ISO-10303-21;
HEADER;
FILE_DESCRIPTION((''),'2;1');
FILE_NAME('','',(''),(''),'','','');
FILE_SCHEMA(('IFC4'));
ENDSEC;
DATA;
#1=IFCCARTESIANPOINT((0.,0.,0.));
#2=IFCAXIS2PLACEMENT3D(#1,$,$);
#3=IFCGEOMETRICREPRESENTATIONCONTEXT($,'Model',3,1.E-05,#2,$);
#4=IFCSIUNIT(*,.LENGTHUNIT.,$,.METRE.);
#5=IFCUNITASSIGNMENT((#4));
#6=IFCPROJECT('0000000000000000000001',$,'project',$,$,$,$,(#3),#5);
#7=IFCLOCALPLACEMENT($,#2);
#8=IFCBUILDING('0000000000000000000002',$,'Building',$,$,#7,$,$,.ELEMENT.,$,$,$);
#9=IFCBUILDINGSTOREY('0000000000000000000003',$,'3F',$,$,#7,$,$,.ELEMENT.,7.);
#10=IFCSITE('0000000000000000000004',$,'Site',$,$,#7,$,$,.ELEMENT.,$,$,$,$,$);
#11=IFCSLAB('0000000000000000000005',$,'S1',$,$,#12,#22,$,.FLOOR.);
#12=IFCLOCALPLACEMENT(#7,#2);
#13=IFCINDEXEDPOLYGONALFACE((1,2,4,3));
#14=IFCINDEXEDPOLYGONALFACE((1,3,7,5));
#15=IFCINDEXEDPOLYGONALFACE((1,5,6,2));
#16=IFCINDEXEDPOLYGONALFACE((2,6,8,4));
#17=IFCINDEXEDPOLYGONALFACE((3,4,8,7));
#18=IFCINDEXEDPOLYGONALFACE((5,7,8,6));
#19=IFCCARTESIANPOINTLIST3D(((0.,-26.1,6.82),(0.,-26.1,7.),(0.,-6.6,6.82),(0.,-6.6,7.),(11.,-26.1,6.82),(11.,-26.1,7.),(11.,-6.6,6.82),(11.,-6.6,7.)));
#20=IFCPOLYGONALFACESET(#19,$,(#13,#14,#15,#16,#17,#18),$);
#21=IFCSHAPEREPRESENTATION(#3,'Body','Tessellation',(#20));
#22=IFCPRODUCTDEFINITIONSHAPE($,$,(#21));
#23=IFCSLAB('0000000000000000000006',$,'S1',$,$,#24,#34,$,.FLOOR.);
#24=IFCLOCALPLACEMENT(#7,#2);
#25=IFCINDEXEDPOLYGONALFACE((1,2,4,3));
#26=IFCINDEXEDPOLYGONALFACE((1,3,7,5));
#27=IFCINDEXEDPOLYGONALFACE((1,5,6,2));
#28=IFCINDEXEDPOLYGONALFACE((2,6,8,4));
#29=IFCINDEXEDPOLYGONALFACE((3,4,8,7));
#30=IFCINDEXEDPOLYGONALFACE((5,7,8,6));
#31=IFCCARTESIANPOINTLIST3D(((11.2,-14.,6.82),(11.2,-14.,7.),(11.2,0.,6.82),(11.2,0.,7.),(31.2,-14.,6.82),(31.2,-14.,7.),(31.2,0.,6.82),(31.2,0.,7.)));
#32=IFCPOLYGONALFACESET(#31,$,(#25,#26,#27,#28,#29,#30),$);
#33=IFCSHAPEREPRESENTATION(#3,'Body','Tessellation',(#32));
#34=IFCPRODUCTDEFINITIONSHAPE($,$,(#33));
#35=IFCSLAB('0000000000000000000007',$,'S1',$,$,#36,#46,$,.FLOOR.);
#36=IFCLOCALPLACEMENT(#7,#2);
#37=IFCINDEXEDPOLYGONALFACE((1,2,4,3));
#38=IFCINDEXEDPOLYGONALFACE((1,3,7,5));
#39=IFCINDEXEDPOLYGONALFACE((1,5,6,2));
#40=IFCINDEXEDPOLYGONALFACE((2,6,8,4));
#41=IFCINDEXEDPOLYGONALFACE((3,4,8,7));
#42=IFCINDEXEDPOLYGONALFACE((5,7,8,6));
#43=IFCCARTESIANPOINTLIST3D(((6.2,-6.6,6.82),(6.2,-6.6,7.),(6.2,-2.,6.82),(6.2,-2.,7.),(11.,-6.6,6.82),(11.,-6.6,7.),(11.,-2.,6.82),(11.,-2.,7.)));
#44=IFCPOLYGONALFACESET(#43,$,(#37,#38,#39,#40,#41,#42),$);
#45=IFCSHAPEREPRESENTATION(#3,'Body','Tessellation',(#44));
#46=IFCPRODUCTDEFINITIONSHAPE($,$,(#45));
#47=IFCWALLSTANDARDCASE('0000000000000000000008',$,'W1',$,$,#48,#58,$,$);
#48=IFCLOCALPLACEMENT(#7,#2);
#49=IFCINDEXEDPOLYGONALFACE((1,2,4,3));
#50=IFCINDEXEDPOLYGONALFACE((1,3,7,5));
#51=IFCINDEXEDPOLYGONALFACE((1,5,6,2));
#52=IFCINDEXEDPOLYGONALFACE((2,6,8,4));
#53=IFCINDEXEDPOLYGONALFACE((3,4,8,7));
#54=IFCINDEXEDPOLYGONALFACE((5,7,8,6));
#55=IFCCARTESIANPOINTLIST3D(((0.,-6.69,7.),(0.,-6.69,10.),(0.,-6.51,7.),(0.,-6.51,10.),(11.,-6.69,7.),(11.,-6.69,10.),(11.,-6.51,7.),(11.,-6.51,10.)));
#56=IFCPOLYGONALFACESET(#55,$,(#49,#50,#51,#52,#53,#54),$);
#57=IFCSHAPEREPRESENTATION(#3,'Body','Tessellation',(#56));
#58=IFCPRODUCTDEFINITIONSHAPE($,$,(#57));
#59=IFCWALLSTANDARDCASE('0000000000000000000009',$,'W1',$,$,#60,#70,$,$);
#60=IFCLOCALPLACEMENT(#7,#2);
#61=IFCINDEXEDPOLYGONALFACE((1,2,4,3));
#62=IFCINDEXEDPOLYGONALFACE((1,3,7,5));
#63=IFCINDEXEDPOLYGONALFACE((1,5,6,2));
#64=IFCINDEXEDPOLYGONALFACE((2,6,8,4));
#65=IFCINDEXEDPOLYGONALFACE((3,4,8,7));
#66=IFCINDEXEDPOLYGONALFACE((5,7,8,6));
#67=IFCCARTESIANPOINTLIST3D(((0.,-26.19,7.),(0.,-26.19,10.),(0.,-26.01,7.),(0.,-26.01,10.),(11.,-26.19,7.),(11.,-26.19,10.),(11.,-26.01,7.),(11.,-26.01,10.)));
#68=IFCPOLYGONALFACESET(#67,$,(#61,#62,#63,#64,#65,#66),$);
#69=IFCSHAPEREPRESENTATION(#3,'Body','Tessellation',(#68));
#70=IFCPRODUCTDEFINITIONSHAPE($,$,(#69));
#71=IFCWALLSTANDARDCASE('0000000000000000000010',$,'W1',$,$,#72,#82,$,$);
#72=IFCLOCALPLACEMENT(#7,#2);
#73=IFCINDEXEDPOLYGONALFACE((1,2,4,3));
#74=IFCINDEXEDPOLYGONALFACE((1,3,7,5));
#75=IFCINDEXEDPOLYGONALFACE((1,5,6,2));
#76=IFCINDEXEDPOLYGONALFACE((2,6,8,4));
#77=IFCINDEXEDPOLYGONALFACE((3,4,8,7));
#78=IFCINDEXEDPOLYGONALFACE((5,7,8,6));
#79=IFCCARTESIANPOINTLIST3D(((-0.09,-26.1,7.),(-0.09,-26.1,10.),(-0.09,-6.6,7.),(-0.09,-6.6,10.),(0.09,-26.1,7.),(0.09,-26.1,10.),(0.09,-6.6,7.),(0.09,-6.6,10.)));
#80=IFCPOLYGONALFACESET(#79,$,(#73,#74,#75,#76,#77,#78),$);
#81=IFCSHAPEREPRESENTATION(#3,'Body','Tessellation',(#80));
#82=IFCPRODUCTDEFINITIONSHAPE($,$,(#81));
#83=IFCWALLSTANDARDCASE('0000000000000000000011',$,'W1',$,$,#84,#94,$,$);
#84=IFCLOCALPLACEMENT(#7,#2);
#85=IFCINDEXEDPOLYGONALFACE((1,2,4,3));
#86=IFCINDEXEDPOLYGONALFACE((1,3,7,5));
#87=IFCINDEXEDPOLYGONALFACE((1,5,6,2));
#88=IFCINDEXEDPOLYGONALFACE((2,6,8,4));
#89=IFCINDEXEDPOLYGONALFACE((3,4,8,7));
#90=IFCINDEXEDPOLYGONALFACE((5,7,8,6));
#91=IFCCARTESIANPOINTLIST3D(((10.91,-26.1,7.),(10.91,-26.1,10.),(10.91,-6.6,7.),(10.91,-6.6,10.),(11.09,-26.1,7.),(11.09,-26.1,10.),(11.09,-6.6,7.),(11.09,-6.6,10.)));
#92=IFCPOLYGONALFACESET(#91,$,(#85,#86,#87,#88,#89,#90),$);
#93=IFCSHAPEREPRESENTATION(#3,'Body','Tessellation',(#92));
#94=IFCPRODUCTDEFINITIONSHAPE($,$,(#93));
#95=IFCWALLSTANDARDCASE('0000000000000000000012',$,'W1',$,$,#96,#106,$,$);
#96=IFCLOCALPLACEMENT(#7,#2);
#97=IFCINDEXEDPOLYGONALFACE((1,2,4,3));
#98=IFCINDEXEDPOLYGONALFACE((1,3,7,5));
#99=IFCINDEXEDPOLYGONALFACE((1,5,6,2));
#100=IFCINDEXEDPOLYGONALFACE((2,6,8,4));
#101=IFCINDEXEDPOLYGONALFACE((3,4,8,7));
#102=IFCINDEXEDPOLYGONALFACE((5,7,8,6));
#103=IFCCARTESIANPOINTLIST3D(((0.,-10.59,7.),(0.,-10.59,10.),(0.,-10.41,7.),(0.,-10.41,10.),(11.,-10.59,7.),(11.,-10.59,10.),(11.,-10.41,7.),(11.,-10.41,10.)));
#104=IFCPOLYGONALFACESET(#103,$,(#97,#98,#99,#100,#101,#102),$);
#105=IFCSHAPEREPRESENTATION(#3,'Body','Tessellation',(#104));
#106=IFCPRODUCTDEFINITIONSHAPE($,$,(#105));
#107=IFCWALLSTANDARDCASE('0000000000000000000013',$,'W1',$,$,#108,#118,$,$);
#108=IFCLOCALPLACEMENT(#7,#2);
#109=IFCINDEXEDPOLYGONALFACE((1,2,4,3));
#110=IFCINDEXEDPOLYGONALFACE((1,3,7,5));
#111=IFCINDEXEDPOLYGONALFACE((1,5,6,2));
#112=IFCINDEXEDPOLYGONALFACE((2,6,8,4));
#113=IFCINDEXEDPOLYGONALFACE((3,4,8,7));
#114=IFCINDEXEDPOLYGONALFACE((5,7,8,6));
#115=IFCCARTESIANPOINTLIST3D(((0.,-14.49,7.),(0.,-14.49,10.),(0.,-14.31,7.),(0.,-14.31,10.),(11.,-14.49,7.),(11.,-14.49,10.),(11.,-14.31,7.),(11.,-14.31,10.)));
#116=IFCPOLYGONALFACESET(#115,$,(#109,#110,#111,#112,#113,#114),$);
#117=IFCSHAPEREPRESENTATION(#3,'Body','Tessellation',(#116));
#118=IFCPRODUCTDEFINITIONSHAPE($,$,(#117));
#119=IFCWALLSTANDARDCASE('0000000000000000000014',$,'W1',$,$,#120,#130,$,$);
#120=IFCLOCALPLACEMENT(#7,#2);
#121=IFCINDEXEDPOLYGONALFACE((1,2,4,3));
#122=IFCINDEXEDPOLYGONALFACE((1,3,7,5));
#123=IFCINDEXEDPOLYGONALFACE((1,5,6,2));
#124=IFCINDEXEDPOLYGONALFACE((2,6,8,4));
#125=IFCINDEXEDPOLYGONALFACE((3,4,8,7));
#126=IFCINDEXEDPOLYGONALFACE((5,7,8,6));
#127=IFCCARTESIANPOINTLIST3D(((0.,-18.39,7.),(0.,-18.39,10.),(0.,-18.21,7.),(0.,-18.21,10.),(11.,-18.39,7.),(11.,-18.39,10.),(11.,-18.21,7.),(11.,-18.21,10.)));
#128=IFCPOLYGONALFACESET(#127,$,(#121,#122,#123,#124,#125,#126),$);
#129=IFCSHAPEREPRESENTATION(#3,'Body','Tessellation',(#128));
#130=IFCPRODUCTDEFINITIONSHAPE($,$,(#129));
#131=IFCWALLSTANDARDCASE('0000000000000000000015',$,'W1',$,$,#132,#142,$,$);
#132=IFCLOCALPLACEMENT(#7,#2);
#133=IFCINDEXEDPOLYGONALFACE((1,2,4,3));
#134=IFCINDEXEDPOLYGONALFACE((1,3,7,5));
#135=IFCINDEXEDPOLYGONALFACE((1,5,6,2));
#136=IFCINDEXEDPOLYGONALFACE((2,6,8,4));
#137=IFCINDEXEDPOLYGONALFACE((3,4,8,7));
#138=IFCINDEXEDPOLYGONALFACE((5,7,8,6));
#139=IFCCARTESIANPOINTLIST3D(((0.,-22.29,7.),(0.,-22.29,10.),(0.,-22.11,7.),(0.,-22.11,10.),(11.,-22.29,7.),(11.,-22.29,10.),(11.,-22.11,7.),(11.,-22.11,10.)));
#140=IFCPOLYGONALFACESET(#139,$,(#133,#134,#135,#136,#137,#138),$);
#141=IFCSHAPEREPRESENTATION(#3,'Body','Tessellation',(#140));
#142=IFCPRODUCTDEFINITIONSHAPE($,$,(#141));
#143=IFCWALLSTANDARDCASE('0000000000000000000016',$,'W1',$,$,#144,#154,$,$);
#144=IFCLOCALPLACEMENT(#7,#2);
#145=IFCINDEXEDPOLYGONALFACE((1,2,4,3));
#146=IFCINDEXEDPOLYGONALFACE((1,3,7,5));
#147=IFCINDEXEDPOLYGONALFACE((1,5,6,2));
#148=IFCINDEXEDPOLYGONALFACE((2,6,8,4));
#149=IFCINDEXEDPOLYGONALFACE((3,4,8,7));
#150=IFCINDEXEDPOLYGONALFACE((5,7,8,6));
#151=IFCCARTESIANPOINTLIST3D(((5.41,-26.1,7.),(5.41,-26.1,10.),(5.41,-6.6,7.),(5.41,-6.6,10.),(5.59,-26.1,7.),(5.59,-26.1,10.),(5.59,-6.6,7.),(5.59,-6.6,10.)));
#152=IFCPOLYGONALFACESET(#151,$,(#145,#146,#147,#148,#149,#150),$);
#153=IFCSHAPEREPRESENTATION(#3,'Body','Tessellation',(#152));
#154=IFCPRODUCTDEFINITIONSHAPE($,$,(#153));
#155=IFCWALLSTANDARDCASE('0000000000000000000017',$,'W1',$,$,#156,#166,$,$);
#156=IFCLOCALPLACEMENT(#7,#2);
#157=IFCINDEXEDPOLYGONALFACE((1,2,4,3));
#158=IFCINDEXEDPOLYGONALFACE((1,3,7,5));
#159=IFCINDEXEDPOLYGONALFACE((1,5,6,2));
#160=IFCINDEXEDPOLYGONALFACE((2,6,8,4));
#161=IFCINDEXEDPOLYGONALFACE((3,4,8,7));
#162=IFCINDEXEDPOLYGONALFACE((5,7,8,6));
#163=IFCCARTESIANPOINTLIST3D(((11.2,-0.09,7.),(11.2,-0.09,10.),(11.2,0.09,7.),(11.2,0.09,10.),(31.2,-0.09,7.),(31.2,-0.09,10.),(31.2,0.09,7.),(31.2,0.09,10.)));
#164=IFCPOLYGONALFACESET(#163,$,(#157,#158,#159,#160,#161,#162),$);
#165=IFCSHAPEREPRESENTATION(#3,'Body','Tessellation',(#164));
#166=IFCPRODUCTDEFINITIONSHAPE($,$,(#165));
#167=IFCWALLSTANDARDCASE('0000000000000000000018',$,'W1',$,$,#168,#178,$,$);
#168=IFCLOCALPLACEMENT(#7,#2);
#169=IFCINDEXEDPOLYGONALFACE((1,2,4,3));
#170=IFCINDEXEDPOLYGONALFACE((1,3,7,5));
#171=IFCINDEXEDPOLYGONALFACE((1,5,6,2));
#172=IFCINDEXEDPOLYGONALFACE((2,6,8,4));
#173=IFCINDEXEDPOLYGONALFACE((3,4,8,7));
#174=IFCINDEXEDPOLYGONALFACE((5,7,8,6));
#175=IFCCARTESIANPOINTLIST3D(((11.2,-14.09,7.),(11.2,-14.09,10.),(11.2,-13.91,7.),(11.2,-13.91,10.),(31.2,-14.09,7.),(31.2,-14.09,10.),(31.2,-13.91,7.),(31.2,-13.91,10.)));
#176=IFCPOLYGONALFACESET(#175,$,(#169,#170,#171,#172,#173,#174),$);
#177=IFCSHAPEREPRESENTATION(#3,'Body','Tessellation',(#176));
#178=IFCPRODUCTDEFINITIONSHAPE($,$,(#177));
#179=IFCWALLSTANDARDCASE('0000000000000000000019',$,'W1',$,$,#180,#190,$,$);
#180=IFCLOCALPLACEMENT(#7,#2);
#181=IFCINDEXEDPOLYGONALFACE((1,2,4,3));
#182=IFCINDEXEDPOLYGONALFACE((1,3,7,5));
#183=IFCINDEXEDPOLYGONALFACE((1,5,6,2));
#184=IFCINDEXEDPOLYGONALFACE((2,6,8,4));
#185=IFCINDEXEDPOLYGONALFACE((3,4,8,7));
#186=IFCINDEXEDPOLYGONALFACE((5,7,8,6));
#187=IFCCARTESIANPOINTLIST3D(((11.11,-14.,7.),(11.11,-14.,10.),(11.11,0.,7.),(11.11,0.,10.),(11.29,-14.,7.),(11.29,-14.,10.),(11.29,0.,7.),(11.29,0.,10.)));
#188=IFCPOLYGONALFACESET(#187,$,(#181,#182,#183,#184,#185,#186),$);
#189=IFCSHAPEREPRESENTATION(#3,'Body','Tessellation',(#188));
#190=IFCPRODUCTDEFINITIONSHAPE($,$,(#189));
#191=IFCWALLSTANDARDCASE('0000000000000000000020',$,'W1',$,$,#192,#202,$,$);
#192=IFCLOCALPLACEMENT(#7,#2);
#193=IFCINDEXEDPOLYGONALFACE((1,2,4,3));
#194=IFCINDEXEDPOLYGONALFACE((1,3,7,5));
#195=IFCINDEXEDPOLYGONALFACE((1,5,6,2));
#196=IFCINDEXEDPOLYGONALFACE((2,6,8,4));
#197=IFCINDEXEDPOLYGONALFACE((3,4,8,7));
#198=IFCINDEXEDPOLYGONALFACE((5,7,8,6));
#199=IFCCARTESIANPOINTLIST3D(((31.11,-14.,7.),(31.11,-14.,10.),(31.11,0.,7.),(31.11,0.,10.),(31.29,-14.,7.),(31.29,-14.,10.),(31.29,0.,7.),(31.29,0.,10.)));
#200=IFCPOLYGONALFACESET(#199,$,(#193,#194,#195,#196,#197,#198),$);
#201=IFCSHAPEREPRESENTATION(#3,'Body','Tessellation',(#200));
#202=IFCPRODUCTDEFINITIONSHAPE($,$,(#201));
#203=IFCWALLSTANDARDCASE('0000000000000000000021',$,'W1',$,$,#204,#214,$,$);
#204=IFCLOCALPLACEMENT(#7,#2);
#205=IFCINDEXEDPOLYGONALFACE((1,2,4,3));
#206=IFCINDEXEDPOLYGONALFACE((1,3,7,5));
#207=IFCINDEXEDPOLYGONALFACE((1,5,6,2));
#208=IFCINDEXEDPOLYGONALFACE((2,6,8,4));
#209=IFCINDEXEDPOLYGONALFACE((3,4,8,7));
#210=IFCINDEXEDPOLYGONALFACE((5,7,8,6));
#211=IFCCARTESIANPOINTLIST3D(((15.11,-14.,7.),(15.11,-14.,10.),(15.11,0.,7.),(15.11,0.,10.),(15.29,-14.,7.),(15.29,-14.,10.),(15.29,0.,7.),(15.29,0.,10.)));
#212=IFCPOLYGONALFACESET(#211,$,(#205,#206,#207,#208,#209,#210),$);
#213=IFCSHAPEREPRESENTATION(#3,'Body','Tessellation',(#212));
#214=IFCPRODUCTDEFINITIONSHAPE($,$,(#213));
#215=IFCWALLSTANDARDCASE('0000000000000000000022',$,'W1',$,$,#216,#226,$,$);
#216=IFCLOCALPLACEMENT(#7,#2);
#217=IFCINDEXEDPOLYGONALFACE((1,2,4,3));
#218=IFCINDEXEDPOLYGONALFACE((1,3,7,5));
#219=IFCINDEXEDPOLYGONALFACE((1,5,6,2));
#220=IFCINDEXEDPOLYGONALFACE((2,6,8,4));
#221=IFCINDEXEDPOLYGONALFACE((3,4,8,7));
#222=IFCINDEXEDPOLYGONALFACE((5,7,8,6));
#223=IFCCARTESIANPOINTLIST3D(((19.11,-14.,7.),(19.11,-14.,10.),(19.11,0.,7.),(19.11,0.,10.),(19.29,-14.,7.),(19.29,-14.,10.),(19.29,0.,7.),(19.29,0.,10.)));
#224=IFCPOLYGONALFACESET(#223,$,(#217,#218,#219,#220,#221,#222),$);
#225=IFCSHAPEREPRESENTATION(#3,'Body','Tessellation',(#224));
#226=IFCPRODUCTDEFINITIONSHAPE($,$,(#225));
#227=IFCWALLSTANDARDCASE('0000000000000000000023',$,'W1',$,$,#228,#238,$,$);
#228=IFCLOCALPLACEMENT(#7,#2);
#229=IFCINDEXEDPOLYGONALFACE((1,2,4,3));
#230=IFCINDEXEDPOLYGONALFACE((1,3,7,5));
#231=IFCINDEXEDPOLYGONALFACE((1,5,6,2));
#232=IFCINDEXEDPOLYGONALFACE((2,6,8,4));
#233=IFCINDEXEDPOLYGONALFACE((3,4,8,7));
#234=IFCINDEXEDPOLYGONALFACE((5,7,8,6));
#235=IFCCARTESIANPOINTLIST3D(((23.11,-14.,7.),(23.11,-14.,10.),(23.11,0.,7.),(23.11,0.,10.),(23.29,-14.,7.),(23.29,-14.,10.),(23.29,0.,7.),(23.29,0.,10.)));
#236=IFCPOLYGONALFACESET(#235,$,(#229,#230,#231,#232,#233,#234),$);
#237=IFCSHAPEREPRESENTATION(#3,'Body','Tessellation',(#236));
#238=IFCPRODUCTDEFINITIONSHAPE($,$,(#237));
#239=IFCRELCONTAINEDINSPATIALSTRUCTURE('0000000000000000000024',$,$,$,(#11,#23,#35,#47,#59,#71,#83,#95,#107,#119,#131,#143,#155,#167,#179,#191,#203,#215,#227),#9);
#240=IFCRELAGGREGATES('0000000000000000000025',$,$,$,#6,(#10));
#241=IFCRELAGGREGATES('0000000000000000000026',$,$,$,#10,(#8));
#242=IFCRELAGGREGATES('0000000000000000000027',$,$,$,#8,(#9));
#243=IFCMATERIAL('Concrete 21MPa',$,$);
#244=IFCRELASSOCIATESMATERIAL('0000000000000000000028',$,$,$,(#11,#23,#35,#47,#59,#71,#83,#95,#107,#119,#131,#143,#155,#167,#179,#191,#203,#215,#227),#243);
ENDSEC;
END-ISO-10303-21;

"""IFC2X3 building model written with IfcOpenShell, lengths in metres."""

from ifc_helpers import new_model, si_unit, frame, origin, origin_2d, place, context, project, spatial, rectangle, extrude, material, element, save


model = new_model("IFC2X3")

# Units and contexts
model_context = context("Model", 3, precision=1e-05, world=origin())
ifc_project = project(units=[si_unit("LENGTHUNIT", "METRE")], contexts=[model_context])

# Site, building, storey
placement = place(None, origin())
site = spatial("IfcSite", under=ifc_project, at=placement, Name="Site", CompositionType="ELEMENT")
building = spatial("IfcBuilding", under=site, at=placement, Name="Building", CompositionType="ELEMENT")
storey = spatial("IfcBuildingStorey", under=building, at=placement, Name="3F", CompositionType="ELEMENT", Elevation=7.0)

# Slabs
ifc_material_1 = material(Name="Concrete 21MPa")
slab_1_placement = place(None, frame((5.5, -16.35, 6.82)))
element("IfcSlab", 1, at=slab_1_placement, inside=storey, material=ifc_material_1, Name="S1", PredefinedType="FLOOR", context=model_context, shape_type="SweptSolid", body=[
    extrude(rectangle(XDim=11.0, YDim=19.5, at=origin_2d()), origin(), (0.0, 0.0, 1.0), 0.18),
])
slab_2_placement = place(None, frame((21.2, -7.0, 6.82)))
element("IfcSlab", 2, at=slab_2_placement, inside=storey, material=ifc_material_1, Name="S1", PredefinedType="FLOOR", context=model_context, shape_type="SweptSolid", body=[
    extrude(rectangle(XDim=20.0, YDim=14.0, at=origin_2d()), origin(), (0.0, 0.0, 1.0), 0.18),
])
slab_3_placement = place(None, frame((8.6, -4.3, 6.82)))
element("IfcSlab", 3, at=slab_3_placement, inside=storey, material=ifc_material_1, Name="S1", PredefinedType="FLOOR", context=model_context, shape_type="SweptSolid", body=[
    extrude(rectangle(XDim=4.8, YDim=4.6, at=origin_2d()), origin(), (0.0, 0.0, 1.0), 0.18),
])

# Walls
for number, where, name in (
    (4, (5.5, -6.6, 7.0), "W1"),
    (5, (5.5, -26.1, 7.0), "W1"),
):
    element("IfcWallStandardCase", number, at=place(None, frame(where)), inside=storey, material=ifc_material_1, Name=name, context=model_context, shape_type="SweptSolid", body=[
        extrude(rectangle(XDim=11.0, YDim=0.18, at=origin_2d()), origin(), (0.0, 0.0, 1.0), 3.0),
    ])
for number, where, name in (
    (6, (0.0, -16.35, 7.0), "W1"),
    (7, (11.0, -16.35, 7.0), "W1"),
):
    element("IfcWallStandardCase", number, at=place(None, frame(where)), inside=storey, material=ifc_material_1, Name=name, context=model_context, shape_type="SweptSolid", body=[
        extrude(rectangle(XDim=0.18, YDim=19.5, at=origin_2d()), origin(), (0.0, 0.0, 1.0), 3.0),
    ])
for number, where, name in (
    (8, (5.5, -10.5, 7.0), "W1"),
    (9, (5.5, -14.4, 7.0), "W1"),
    (10, (5.5, -18.3, 7.0), "W1"),
    (11, (5.5, -22.2, 7.0), "W1"),
):
    element("IfcWallStandardCase", number, at=place(None, frame(where)), inside=storey, material=ifc_material_1, Name=name, context=model_context, shape_type="SweptSolid", body=[
        extrude(rectangle(XDim=11.0, YDim=0.18, at=origin_2d()), origin(), (0.0, 0.0, 1.0), 3.0),
    ])
wall_1_placement = place(None, frame((5.5, -16.35, 7.0)))
element("IfcWallStandardCase", 12, at=wall_1_placement, inside=storey, material=ifc_material_1, Name="W1", context=model_context, shape_type="SweptSolid", body=[
    extrude(rectangle(XDim=0.18, YDim=19.5, at=origin_2d()), origin(), (0.0, 0.0, 1.0), 3.0),
])
for number, where, name in (
    (13, (21.2, 0.0, 7.0), "W1"),
    (14, (21.2, -14.0, 7.0), "W1"),
):
    element("IfcWallStandardCase", number, at=place(None, frame(where)), inside=storey, material=ifc_material_1, Name=name, context=model_context, shape_type="SweptSolid", body=[
        extrude(rectangle(XDim=20.0, YDim=0.18, at=origin_2d()), origin(), (0.0, 0.0, 1.0), 3.0),
    ])
for number, where, name in (
    (15, (11.2, -7.0, 7.0), "W1"),
    (16, (31.2, -7.0, 7.0), "W1"),
    (17, (15.2, -7.0, 7.0), "W1"),
    (18, (19.2, -7.0, 7.0), "W1"),
    (19, (23.2, -7.0, 7.0), "W1"),
):
    element("IfcWallStandardCase", number, at=place(None, frame(where)), inside=storey, material=ifc_material_1, Name=name, context=model_context, shape_type="SweptSolid", body=[
        extrude(rectangle(XDim=0.18, YDim=14.0, at=origin_2d()), origin(), (0.0, 0.0, 1.0), 3.0),
    ])

save(model, "model.ifc")
